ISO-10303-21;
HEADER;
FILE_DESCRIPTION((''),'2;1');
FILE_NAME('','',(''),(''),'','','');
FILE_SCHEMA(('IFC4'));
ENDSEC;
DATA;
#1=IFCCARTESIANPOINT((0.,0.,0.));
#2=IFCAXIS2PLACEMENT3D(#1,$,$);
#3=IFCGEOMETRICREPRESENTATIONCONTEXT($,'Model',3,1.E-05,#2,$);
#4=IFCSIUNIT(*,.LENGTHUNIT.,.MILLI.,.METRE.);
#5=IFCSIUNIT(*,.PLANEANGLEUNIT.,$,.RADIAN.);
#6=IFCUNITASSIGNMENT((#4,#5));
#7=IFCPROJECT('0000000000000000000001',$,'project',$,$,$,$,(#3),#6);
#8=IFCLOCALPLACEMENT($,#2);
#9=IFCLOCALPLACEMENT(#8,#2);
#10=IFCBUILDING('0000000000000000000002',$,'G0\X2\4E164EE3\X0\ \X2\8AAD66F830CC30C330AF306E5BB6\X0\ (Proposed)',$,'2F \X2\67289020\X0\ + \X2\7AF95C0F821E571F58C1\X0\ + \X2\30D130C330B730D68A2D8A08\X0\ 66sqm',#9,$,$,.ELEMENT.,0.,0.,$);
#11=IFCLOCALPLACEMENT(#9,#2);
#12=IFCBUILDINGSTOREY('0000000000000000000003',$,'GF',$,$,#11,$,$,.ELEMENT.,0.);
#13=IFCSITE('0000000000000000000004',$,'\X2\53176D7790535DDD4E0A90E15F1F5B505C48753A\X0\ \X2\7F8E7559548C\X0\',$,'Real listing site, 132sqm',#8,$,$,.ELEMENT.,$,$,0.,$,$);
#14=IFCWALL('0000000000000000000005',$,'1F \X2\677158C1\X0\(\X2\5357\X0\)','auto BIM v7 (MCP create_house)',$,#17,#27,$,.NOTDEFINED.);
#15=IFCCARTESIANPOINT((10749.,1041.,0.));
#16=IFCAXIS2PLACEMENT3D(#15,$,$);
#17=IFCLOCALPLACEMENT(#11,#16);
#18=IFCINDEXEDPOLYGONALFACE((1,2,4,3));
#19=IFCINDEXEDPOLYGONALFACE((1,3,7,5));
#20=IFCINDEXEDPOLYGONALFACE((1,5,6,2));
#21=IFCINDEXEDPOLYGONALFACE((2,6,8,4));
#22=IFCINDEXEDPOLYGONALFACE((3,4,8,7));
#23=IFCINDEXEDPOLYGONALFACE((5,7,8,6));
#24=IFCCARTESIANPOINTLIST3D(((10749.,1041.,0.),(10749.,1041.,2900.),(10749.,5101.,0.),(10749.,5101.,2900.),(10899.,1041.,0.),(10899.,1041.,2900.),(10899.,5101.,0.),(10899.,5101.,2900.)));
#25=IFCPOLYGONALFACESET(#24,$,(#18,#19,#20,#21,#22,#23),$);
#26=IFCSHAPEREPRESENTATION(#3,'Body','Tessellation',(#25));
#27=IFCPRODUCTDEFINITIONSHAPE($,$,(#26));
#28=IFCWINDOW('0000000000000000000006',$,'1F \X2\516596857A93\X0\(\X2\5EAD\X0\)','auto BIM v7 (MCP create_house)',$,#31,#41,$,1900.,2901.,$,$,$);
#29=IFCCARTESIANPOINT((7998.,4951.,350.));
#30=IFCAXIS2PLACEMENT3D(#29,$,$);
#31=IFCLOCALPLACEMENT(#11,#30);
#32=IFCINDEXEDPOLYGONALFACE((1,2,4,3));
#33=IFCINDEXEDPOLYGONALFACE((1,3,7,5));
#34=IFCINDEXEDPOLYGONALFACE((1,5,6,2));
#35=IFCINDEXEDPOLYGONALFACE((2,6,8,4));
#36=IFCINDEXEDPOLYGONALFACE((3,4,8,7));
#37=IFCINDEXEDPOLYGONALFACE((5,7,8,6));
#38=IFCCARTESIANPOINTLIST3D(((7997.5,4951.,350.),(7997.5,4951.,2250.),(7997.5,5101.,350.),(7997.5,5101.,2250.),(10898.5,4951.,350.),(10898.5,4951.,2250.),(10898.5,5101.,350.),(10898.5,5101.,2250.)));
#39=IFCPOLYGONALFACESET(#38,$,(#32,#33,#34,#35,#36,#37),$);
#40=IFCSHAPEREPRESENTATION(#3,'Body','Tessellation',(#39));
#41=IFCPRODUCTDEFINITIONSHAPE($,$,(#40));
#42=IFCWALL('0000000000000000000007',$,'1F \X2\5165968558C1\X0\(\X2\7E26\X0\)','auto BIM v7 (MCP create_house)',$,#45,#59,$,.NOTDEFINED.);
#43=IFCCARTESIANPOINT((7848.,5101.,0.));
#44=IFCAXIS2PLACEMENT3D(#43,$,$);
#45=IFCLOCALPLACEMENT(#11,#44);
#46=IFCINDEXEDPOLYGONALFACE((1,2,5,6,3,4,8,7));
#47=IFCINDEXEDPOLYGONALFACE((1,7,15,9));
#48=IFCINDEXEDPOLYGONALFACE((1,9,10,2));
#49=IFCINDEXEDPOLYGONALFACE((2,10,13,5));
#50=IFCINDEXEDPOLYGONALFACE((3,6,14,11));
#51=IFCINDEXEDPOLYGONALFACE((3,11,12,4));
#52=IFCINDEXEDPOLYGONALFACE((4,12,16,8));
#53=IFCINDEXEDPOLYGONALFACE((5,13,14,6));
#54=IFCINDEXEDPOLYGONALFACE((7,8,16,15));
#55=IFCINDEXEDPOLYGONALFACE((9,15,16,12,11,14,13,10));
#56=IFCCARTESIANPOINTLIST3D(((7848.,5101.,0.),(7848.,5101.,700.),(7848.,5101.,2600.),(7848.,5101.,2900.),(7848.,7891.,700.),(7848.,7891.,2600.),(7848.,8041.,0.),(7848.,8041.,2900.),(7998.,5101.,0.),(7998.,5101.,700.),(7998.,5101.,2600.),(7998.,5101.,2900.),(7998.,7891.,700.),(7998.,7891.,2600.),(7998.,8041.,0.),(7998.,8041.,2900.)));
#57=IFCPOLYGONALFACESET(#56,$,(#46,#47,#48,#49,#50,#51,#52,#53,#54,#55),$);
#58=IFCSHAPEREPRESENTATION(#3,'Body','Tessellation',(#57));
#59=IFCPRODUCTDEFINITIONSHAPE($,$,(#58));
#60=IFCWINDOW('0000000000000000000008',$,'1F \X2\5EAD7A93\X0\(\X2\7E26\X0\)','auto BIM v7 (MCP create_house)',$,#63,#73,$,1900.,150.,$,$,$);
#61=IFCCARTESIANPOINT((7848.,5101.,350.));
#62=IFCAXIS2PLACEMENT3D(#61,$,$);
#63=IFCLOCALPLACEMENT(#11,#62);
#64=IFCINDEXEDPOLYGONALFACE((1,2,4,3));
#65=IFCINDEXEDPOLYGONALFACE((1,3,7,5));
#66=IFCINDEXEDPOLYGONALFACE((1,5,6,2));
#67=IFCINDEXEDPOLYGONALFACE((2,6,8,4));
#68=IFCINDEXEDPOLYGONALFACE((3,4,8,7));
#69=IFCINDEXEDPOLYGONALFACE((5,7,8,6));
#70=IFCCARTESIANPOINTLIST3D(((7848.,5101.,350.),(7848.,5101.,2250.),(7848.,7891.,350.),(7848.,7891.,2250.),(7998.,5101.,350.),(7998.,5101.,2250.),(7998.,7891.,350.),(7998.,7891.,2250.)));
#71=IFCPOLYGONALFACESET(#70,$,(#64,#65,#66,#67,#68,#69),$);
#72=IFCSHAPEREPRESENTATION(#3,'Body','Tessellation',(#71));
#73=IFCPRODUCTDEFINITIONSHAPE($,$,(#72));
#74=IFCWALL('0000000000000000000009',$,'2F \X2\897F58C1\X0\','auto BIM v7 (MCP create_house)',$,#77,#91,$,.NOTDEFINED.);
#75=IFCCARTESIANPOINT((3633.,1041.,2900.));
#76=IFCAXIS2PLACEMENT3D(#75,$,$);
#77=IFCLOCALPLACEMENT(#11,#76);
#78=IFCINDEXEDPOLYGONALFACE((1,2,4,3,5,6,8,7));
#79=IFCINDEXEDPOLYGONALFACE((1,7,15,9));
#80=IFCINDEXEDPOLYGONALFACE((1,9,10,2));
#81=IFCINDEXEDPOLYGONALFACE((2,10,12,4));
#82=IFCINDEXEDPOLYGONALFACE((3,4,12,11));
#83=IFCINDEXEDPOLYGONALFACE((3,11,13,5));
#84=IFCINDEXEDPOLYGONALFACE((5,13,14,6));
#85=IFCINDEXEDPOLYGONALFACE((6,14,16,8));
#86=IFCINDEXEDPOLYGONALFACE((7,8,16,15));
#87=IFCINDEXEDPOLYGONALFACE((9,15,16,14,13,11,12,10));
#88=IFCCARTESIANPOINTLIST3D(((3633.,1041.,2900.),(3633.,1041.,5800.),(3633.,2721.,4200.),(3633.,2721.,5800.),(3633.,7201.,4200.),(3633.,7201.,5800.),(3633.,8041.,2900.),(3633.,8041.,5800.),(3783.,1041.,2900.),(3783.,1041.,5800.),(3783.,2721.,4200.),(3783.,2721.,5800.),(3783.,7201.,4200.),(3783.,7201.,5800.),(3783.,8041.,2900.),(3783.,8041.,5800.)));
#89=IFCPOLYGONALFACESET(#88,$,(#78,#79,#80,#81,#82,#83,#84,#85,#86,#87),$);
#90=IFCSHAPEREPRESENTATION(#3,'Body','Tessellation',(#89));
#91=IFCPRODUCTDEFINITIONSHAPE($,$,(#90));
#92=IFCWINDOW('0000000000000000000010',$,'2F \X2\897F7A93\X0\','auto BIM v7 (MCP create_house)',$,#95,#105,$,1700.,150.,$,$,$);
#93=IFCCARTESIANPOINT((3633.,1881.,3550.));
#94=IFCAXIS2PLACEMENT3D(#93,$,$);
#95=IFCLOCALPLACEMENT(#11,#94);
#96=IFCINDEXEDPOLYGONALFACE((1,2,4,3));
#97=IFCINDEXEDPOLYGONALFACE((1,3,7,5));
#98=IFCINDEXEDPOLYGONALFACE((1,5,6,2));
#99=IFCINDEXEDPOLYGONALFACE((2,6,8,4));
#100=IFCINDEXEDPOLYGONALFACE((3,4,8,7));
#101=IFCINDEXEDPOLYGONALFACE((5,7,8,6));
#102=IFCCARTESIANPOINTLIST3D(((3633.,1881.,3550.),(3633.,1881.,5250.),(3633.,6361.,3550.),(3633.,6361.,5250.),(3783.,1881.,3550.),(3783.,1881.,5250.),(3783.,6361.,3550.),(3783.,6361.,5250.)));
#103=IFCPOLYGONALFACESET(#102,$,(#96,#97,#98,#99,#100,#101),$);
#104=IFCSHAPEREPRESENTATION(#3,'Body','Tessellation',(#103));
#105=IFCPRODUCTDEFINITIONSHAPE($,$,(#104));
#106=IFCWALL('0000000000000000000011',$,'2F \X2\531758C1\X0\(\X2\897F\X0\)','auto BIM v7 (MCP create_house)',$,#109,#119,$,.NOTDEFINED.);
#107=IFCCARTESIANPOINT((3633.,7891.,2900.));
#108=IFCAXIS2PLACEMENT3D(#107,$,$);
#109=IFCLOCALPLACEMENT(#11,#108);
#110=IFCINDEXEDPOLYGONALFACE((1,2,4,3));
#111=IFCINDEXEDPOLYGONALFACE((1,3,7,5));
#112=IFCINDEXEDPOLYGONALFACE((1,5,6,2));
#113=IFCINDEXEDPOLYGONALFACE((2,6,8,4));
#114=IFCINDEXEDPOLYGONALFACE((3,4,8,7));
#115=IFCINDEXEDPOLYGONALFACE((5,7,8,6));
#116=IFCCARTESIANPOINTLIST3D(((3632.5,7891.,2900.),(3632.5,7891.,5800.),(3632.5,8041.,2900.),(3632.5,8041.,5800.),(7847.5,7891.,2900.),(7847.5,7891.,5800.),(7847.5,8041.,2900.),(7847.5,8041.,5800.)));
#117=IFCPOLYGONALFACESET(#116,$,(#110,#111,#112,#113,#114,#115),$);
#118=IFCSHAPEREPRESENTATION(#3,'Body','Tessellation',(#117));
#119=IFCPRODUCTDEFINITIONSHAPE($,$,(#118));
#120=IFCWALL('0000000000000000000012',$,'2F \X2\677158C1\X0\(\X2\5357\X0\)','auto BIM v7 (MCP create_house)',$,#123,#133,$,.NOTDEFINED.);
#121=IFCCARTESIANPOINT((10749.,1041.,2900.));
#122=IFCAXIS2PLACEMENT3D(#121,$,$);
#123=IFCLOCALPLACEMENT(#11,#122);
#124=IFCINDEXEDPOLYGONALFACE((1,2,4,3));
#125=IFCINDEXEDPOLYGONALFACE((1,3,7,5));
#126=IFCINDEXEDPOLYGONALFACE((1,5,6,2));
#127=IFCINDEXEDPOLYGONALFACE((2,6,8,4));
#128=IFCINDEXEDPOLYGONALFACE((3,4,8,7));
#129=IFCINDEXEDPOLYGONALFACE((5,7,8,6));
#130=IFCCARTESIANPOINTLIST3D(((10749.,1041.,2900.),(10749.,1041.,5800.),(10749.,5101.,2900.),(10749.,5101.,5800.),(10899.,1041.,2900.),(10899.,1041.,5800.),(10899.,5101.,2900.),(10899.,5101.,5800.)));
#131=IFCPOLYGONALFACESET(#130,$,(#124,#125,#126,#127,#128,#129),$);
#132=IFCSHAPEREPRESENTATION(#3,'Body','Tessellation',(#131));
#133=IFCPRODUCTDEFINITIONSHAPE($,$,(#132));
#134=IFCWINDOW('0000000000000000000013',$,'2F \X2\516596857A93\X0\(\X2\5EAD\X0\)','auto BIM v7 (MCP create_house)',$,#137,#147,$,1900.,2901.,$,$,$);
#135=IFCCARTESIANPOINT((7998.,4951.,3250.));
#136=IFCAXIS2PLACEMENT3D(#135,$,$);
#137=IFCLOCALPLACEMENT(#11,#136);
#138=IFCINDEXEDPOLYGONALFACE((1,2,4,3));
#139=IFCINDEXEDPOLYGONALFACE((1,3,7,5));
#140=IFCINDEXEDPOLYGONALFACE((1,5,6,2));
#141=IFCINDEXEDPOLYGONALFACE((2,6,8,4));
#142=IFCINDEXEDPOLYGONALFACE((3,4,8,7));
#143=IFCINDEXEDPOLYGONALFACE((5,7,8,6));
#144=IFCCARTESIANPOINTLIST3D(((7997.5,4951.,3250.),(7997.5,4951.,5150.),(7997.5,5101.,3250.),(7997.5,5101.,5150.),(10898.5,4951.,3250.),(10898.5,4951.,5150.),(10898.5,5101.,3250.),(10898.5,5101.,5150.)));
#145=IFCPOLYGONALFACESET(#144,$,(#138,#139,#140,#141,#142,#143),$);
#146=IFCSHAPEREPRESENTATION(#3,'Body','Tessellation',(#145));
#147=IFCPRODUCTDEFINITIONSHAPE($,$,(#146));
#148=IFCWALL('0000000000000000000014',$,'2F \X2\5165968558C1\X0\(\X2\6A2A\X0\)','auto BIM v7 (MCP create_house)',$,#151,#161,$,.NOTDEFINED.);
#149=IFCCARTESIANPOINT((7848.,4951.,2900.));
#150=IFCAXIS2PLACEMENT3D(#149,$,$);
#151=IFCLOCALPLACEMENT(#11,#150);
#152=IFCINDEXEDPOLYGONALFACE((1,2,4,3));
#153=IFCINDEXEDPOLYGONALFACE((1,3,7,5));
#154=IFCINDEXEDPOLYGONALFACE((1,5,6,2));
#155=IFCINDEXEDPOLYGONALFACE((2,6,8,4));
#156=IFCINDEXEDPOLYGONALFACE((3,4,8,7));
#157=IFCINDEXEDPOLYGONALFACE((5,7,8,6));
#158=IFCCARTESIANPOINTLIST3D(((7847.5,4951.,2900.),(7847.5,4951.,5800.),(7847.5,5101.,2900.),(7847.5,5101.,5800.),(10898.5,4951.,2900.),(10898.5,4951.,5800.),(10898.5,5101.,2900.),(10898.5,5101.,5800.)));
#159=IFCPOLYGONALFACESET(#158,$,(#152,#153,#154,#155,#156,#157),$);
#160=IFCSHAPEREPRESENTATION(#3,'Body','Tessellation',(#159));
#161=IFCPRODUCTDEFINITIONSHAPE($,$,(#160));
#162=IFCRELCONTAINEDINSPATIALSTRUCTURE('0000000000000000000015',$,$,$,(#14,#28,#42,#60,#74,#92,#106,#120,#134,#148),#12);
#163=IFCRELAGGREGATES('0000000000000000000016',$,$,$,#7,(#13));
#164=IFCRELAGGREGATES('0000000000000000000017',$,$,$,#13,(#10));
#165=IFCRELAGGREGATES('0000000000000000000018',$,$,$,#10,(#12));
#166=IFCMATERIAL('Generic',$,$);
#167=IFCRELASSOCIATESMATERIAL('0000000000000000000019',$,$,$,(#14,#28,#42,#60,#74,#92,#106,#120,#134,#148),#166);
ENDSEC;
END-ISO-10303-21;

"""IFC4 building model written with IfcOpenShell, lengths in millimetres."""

from ifc_helpers import new_model, si_unit, frame, frame_2d, origin, place, context, project, spatial, rectangle, extrude, material, element, fill, save


model = new_model("IFC4")

# Units and contexts
model_context = context("Model", 3, precision=1e-05, world=origin())
ifc_project = project(units=[si_unit("LENGTHUNIT", "METRE", prefix="MILLI"), si_unit("PLANEANGLEUNIT", "RADIAN")], contexts=[model_context])

# Site, building, storey
site_placement = place(None, origin())
site = spatial("IfcSite", under=ifc_project, at=site_placement, Name="北海道川上郡弟子屈町 美留和", ObjectType="Real listing site, 132sqm", CompositionType="ELEMENT", RefElevation=0.0)
building_placement = place(site_placement, origin())
building = spatial("IfcBuilding", under=site, at=building_placement, Name="G0世代 読書ヌックの家 (Proposed)", ObjectType="2F 木造 + 竹小舞土壁 + パッシブ設計 66sqm", CompositionType="ELEMENT", ElevationOfRefHeight=0.0, ElevationOfTerrain=0.0)
storey_placement = place(building_placement, origin())
storey = spatial("IfcBuildingStorey", under=building, at=storey_placement, Name="GF", CompositionType="ELEMENT", Elevation=0.0)

# Shared definitions
ifc_material = material(Name="Generic")

# Wall, opening, window
wall_1_placement = place(storey_placement, frame((10749.0, 1041.0, 0.0)))
wall_1 = element("IfcWall", 1, at=wall_1_placement, inside=storey, material=ifc_material, Name="1F 東壁(南)", Description="auto BIM v7 (MCP create_house)", PredefinedType="NOTDEFINED", context=model_context, shape_type="SweptSolid", body=[
    extrude(rectangle(XDim=150.0, YDim=4060.0, at=frame_2d((75.0, 2030.0))), frame((10749.0, 1041.0, 0.0)), (0.0, 0.0, 1.0), 2900.0),
])
opening_1_placement = place(storey_placement, frame((7998.0, 4951.0, 350.0)))
opening_1 = element("IfcOpeningElement", 2, at=opening_1_placement, cuts=wall_1, PredefinedType="NOTDEFINED", context=model_context, shape_type="SweptSolid", body=[
    extrude(rectangle(XDim=2901.0, YDim=150.0, at=frame_2d((1450.0, 75.0))), frame((7998.0, 4951.0, 350.0)), (0.0, 0.0, 1.0), 1900.0),
])
window_1_placement = place(storey_placement, frame((7998.0, 4951.0, 350.0)))
window_1 = element("IfcWindow", 3, at=window_1_placement, inside=storey, material=ifc_material, Name="1F 入隅窓(庭)", Description="auto BIM v7 (MCP create_house)", OverallHeight=1900.0, OverallWidth=2901.0, context=model_context, shape_type="SweptSolid", body=[
    extrude(rectangle(XDim=2901.0, YDim=150.0, at=frame_2d((1450.0, 75.0))), frame((7998.0, 4951.0, 350.0)), (0.0, 0.0, 1.0), 1900.0),
])
fill(opening_1, window_1)

# Wall, opening, window
wall_2_placement = place(storey_placement, frame((7848.0, 5101.0, 0.0)))
wall_2 = element("IfcWall", 4, at=wall_2_placement, inside=storey, material=ifc_material, Name="1F 入隅壁(縦)", Description="auto BIM v7 (MCP create_house)", PredefinedType="NOTDEFINED", context=model_context, shape_type="SweptSolid", body=[
    extrude(rectangle(XDim=150.0, YDim=2940.0, at=frame_2d((75.0, 1470.0))), frame((7848.0, 5101.0, 0.0)), (0.0, 0.0, 1.0), 2900.0),
])
opening_2_placement = place(storey_placement, frame((7848.0, 5101.0, 350.0)))
opening_2 = element("IfcOpeningElement", 5, at=opening_2_placement, cuts=wall_2, PredefinedType="NOTDEFINED", context=model_context, shape_type="SweptSolid", body=[
    extrude(rectangle(XDim=150.0, YDim=2790.0, at=frame_2d((75.0, 1395.0))), frame((7848.0, 5101.0, 350.0)), (0.0, 0.0, 1.0), 1900.0),
])
window_2_placement = place(storey_placement, frame((7848.0, 5101.0, 350.0)))
window_2 = element("IfcWindow", 6, at=window_2_placement, inside=storey, material=ifc_material, Name="1F 庭窓(縦)", Description="auto BIM v7 (MCP create_house)", OverallHeight=1900.0, OverallWidth=150.0, context=model_context, shape_type="SweptSolid", body=[
    extrude(rectangle(XDim=150.0, YDim=2790.0, at=frame_2d((75.0, 1395.0))), frame((7848.0, 5101.0, 350.0)), (0.0, 0.0, 1.0), 1900.0),
])
fill(opening_2, window_2)

# Wall, opening, window
wall_3_placement = place(storey_placement, frame((3633.0, 1041.0, 2900.0)))
wall_3 = element("IfcWall", 7, at=wall_3_placement, inside=storey, material=ifc_material, Name="2F 西壁", Description="auto BIM v7 (MCP create_house)", PredefinedType="NOTDEFINED", context=model_context, shape_type="SweptSolid", body=[
    extrude(rectangle(XDim=150.0, YDim=7000.0, at=frame_2d((75.0, 3500.0))), frame((3633.0, 1041.0, 2900.0)), (0.0, 0.0, 1.0), 2900.0),
])
opening_3_placement = place(storey_placement, frame((3633.0, 1881.0, 3550.0)))
opening_3 = element("IfcOpeningElement", 8, at=opening_3_placement, cuts=wall_3, PredefinedType="NOTDEFINED", context=model_context, shape_type="SweptSolid", body=[
    extrude(rectangle(XDim=150.0, YDim=4480.0, at=frame_2d((75.0, 2240.0))), frame((3633.0, 1881.0, 3550.0)), (0.0, 0.0, 1.0), 1700.0),
])
window_3_placement = place(storey_placement, frame((3633.0, 1881.0, 3550.0)))
window_3 = element("IfcWindow", 9, at=window_3_placement, inside=storey, material=ifc_material, Name="2F 西窓", Description="auto BIM v7 (MCP create_house)", OverallHeight=1700.0, OverallWidth=150.0, context=model_context, shape_type="SweptSolid", body=[
    extrude(rectangle(XDim=150.0, YDim=4480.0, at=frame_2d((75.0, 2240.0))), frame((3633.0, 1881.0, 3550.0)), (0.0, 0.0, 1.0), 1700.0),
])
fill(opening_3, window_3)

# Wall
wall_4_placement = place(storey_placement, frame((3633.0, 7891.0, 2900.0)))
element("IfcWall", 10, at=wall_4_placement, inside=storey, material=ifc_material, Name="2F 北壁(西)", Description="auto BIM v7 (MCP create_house)", PredefinedType="NOTDEFINED", context=model_context, shape_type="SweptSolid", body=[
    extrude(rectangle(XDim=4215.0, YDim=150.0, at=frame_2d((2107.0, 75.0))), frame((3633.0, 7891.0, 2900.0)), (0.0, 0.0, 1.0), 2900.0),
])

# Wall, opening, window
wall_5_placement = place(storey_placement, frame((10749.0, 1041.0, 2900.0)))
wall_5 = element("IfcWall", 11, at=wall_5_placement, inside=storey, material=ifc_material, Name="2F 東壁(南)", Description="auto BIM v7 (MCP create_house)", PredefinedType="NOTDEFINED", context=model_context, shape_type="SweptSolid", body=[
    extrude(rectangle(XDim=150.0, YDim=4060.0, at=frame_2d((75.0, 2030.0))), frame((10749.0, 1041.0, 2900.0)), (0.0, 0.0, 1.0), 2900.0),
])
opening_4_placement = place(storey_placement, frame((7998.0, 4951.0, 3250.0)))
opening_4 = element("IfcOpeningElement", 12, at=opening_4_placement, cuts=wall_5, PredefinedType="NOTDEFINED", context=model_context, shape_type="SweptSolid", body=[
    extrude(rectangle(XDim=2901.0, YDim=150.0, at=frame_2d((1450.0, 75.0))), frame((7998.0, 4951.0, 3250.0)), (0.0, 0.0, 1.0), 1900.0),
])
window_4_placement = place(storey_placement, frame((7998.0, 4951.0, 3250.0)))
window_4 = element("IfcWindow", 13, at=window_4_placement, inside=storey, material=ifc_material, Name="2F 入隅窓(庭)", Description="auto BIM v7 (MCP create_house)", OverallHeight=1900.0, OverallWidth=2901.0, context=model_context, shape_type="SweptSolid", body=[
    extrude(rectangle(XDim=2901.0, YDim=150.0, at=frame_2d((1450.0, 75.0))), frame((7998.0, 4951.0, 3250.0)), (0.0, 0.0, 1.0), 1900.0),
])
fill(opening_4, window_4)

# Wall
wall_6_placement = place(storey_placement, frame((7848.0, 4951.0, 2900.0)))
element("IfcWall", 14, at=wall_6_placement, inside=storey, material=ifc_material, Name="2F 入隅壁(横)", Description="auto BIM v7 (MCP create_house)", PredefinedType="NOTDEFINED", context=model_context, shape_type="SweptSolid", body=[
    extrude(rectangle(XDim=3051.0, YDim=150.0, at=frame_2d((1525.0, 75.0))), frame((7848.0, 4951.0, 2900.0)), (0.0, 0.0, 1.0), 2900.0),
])

save(model, "model.ifc")
